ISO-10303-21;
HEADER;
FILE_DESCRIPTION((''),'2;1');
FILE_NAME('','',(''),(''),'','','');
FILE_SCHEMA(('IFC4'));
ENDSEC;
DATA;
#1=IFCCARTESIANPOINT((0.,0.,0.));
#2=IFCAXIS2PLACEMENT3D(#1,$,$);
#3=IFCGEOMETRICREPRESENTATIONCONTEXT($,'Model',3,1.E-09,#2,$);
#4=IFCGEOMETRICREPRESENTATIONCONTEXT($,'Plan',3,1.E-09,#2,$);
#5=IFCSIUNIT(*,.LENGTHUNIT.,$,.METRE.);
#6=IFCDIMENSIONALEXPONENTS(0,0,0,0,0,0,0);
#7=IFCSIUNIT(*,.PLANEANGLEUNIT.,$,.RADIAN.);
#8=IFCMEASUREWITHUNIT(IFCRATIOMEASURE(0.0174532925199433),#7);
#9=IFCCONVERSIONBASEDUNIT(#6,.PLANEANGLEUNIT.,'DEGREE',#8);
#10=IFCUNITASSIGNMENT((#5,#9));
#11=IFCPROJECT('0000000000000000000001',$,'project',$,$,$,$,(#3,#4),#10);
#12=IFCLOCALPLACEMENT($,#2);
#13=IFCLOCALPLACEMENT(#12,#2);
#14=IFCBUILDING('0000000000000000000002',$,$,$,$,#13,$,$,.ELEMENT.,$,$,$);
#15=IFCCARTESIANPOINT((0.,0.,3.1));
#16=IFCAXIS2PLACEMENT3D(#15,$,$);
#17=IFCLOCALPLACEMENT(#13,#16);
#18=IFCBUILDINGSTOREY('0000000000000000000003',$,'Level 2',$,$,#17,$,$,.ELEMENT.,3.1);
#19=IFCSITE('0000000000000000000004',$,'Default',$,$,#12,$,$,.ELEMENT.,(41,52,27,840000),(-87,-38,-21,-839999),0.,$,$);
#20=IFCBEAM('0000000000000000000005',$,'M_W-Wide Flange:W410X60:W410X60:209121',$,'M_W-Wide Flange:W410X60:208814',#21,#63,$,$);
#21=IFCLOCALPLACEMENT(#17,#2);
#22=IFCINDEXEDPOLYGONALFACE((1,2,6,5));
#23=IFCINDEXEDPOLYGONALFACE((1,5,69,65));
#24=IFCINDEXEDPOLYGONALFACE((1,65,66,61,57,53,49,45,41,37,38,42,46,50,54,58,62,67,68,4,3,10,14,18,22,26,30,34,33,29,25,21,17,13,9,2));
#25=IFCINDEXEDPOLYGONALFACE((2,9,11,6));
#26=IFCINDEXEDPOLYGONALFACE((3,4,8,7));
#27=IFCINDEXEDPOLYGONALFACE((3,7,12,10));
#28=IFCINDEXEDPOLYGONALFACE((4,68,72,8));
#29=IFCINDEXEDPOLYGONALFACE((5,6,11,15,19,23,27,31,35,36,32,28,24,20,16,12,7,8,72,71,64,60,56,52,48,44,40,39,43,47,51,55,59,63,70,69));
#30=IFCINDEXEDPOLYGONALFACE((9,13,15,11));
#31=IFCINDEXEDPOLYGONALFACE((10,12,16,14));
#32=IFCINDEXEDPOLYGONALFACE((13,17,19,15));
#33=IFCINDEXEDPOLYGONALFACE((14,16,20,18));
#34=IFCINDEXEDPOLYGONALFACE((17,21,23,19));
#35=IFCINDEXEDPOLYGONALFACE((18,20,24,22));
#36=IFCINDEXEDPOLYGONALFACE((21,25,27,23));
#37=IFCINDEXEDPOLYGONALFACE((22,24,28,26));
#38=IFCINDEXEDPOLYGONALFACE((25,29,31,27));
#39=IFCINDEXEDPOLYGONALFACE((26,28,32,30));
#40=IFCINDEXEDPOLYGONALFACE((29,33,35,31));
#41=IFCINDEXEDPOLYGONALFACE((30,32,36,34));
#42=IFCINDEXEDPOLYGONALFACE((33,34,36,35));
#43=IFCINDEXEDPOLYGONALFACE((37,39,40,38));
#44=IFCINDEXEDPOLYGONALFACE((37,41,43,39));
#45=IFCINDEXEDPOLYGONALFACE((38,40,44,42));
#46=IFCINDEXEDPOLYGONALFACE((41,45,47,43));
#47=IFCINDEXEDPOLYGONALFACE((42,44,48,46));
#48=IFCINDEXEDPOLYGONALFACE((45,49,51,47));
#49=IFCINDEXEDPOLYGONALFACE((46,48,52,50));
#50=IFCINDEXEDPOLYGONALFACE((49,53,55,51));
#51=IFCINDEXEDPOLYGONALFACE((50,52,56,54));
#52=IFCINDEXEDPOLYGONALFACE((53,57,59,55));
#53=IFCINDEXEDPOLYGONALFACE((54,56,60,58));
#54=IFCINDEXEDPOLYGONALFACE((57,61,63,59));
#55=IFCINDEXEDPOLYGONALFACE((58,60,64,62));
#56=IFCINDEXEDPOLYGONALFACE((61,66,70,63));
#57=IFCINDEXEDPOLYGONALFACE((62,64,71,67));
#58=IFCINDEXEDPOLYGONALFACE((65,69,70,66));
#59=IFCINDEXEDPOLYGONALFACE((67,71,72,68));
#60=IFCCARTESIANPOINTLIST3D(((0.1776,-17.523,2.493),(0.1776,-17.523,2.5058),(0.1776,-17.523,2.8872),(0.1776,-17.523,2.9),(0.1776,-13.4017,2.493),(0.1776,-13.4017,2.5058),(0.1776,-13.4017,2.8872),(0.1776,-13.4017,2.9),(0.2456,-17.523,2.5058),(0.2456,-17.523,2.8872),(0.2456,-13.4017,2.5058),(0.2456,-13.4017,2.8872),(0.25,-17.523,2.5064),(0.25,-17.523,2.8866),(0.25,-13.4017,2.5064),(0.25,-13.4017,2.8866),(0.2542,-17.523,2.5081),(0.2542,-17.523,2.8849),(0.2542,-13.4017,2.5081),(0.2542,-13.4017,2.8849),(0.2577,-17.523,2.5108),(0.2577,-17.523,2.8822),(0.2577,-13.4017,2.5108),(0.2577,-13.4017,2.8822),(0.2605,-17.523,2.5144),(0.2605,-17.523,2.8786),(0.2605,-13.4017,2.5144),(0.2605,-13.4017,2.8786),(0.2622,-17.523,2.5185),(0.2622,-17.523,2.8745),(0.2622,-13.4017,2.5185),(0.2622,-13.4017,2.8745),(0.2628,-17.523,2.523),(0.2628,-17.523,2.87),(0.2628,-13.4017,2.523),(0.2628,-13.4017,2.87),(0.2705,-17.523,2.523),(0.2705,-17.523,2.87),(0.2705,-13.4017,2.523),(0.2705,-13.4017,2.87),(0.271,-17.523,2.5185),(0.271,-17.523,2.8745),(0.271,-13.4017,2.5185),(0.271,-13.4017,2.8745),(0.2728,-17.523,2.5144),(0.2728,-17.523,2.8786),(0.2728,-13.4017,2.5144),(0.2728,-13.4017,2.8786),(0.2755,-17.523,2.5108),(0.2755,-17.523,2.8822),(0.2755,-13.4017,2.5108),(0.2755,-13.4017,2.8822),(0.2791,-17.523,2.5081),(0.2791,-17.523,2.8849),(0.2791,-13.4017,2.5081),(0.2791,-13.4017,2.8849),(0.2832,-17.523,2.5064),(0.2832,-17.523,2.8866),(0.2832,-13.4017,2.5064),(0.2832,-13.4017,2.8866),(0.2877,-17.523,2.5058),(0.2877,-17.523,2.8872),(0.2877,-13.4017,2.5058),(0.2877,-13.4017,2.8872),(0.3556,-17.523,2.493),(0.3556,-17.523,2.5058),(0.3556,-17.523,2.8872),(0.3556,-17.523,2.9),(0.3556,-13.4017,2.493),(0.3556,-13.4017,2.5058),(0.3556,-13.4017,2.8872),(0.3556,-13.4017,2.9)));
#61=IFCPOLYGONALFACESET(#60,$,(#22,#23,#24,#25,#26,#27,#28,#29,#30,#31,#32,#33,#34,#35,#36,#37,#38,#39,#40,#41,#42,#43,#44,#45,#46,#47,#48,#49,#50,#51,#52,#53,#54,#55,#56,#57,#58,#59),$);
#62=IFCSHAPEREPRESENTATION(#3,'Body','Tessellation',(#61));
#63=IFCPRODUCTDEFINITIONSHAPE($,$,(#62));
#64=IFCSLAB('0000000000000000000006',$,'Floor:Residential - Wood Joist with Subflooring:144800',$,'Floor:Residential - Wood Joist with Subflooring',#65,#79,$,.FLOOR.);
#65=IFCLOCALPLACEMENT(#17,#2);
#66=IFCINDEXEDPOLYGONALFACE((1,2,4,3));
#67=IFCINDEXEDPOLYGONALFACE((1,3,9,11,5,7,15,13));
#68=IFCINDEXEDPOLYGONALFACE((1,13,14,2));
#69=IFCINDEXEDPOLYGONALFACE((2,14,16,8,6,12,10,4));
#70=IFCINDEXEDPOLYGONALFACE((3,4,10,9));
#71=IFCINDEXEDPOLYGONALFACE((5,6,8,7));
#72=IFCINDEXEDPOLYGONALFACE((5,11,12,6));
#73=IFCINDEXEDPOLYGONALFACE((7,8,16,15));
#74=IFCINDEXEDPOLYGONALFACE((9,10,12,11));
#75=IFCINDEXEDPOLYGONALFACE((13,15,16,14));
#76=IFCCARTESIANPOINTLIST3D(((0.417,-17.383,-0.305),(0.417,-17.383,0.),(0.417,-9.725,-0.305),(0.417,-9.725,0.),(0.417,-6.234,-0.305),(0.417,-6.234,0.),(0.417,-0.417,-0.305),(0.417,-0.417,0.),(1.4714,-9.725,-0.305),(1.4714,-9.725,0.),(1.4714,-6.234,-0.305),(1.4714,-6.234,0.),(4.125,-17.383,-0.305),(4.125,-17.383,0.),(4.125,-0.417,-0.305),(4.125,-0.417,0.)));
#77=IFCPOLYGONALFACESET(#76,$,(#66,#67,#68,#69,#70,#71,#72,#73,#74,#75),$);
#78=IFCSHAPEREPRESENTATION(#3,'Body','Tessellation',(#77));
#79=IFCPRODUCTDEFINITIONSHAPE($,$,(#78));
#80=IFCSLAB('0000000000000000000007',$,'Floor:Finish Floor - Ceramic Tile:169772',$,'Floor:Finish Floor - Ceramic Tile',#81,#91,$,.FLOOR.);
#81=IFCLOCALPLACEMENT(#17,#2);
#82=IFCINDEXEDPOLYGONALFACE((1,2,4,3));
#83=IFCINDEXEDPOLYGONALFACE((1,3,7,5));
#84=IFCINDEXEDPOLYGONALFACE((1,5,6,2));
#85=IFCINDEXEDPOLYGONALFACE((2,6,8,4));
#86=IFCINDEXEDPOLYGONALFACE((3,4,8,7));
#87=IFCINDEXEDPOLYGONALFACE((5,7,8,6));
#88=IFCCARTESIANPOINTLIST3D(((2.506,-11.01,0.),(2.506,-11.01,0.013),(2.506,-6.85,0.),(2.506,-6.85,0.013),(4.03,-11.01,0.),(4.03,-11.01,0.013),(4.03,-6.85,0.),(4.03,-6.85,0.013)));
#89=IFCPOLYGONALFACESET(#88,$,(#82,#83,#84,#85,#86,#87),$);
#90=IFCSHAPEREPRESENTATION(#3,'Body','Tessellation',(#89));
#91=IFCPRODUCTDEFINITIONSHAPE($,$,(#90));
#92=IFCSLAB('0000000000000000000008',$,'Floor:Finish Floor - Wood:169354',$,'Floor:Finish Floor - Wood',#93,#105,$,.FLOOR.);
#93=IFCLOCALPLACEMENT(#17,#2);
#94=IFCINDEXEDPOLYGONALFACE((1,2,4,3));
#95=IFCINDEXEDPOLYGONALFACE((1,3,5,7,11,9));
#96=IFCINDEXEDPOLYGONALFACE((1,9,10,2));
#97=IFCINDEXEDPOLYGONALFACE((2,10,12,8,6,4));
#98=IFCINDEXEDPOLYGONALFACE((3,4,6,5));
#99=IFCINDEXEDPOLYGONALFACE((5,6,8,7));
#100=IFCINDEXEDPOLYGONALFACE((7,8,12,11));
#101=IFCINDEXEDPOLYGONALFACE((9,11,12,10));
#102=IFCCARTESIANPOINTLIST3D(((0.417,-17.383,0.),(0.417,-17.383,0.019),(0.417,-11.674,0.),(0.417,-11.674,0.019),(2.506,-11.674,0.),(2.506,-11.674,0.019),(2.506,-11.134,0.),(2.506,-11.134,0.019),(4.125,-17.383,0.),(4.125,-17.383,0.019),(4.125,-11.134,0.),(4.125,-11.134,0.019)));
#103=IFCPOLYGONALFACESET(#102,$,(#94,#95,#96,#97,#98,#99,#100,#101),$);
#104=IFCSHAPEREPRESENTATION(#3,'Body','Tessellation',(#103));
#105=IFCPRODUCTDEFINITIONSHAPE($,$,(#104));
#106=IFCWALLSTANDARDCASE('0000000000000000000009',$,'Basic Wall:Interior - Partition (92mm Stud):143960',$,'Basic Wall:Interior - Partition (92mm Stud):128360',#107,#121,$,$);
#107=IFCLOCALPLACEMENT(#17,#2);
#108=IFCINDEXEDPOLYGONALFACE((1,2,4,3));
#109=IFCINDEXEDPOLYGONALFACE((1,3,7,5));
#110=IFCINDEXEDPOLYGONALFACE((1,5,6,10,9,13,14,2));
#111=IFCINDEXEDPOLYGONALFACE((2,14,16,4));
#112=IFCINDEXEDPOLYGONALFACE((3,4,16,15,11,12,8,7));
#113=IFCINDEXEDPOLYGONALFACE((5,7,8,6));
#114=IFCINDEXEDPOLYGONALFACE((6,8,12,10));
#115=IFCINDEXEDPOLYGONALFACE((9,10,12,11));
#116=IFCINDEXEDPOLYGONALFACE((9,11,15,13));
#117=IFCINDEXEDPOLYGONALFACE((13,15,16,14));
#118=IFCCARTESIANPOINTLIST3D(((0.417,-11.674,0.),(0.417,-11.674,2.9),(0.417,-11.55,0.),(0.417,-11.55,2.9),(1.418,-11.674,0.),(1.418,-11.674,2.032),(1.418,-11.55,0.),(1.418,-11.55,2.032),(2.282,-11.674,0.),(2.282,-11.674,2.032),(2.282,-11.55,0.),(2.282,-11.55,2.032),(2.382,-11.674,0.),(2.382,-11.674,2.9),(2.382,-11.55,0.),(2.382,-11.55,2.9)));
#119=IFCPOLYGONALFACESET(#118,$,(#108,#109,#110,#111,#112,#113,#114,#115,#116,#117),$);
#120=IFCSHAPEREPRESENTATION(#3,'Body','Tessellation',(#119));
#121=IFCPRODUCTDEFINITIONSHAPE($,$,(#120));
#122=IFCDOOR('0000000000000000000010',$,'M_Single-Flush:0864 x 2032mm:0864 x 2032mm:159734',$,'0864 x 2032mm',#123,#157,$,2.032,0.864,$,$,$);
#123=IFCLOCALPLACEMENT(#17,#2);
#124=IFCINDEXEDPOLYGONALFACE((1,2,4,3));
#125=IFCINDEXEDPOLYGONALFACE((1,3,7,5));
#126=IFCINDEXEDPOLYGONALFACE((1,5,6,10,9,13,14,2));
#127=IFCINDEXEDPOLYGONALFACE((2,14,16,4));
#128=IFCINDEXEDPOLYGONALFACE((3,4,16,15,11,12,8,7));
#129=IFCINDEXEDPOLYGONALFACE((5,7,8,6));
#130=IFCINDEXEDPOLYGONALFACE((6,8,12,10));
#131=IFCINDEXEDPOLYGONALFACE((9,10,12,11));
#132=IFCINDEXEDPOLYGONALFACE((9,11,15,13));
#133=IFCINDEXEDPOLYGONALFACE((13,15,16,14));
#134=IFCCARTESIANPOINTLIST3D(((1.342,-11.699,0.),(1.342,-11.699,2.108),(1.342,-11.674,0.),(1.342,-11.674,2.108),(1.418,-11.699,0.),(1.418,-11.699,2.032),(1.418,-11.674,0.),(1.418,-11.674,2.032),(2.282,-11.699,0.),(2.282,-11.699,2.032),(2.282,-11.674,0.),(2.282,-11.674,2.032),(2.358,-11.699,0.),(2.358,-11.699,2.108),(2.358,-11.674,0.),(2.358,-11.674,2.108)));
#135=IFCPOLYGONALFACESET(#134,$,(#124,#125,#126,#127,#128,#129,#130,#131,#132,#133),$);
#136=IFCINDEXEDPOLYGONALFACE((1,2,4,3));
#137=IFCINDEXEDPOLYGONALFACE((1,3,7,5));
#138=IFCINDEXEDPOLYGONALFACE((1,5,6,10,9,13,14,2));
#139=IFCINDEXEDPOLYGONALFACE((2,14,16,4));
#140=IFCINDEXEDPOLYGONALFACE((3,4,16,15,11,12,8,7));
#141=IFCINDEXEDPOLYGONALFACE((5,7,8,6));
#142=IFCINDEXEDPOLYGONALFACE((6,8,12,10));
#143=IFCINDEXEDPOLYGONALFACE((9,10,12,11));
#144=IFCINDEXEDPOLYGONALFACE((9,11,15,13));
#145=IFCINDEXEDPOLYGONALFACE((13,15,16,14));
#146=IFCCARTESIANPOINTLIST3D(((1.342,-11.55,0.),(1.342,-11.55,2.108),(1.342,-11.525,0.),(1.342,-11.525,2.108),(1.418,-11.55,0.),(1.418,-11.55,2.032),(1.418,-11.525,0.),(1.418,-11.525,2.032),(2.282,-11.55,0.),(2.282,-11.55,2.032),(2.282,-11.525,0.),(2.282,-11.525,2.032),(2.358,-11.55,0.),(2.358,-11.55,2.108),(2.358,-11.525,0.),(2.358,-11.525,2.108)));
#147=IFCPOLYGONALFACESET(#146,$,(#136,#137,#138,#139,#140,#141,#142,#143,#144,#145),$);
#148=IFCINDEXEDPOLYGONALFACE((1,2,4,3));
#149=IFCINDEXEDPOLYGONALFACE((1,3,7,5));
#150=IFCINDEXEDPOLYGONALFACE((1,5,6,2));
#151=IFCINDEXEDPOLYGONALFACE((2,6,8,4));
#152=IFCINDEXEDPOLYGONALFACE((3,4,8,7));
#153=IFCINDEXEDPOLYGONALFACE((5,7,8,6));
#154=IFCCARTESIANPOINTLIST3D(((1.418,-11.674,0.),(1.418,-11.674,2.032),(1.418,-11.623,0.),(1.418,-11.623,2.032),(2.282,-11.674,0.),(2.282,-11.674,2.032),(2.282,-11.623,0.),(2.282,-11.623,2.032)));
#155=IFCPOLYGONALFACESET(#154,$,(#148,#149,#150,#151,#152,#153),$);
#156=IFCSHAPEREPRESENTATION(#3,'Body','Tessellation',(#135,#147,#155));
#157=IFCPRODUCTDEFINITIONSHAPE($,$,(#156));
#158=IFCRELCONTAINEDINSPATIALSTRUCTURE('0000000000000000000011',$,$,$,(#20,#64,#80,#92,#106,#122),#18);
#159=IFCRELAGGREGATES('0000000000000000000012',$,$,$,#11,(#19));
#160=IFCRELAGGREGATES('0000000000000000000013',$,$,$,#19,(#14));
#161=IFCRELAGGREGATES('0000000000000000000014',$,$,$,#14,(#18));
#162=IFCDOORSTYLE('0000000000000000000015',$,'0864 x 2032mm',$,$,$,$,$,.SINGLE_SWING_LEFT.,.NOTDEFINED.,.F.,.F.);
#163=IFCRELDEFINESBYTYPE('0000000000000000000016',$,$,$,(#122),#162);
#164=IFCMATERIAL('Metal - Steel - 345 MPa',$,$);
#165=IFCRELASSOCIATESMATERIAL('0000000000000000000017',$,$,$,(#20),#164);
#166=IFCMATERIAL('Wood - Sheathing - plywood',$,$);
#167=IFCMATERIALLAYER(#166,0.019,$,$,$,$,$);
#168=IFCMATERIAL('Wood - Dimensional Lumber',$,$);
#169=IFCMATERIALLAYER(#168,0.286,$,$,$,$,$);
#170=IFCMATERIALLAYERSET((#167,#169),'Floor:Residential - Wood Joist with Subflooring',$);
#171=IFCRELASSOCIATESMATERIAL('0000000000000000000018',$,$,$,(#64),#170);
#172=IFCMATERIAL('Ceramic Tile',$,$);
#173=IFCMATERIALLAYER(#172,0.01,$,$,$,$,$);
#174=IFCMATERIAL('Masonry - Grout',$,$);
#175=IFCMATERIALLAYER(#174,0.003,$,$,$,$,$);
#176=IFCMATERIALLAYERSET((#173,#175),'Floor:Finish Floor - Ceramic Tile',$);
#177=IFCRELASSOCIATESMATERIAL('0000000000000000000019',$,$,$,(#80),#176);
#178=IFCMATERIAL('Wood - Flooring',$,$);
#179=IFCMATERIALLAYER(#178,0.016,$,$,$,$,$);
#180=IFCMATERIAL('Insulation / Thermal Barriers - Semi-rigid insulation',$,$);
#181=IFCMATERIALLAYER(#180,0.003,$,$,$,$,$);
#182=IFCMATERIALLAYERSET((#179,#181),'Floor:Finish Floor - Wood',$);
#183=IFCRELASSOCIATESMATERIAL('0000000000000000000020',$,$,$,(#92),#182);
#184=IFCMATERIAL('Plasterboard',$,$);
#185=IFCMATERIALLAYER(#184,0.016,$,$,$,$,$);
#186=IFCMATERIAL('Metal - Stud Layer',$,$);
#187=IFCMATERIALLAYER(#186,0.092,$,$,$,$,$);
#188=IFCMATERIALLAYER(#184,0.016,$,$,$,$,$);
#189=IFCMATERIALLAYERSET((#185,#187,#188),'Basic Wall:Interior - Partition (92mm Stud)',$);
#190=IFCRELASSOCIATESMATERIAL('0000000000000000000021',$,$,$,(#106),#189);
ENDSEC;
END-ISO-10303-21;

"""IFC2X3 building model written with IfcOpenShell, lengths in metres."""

from ifc_helpers import new_model, entity, si_unit, converted_unit, frame, frame_2d, origin, origin_2d_with_axis, place, context, project, spatial, polyline, circle_curve, parameter, trimmed, segment, composite_curve, rectangle, outline, extrude, source, transform, mapped, material, layer, layer_set, layer_usage, type_object, type_shapes, element, fill, save


model = new_model("IFC2X3")

# Units and contexts
model_context = context("Model", 3, precision=1e-09, world=origin())
plan_context = context("Plan", 3, precision=1e-09, world=origin())
ifc_project = project(units=[si_unit("LENGTHUNIT", "METRE"), converted_unit("PLANEANGLEUNIT", "DEGREE", entity("IfcRatioMeasure", 0.0174532925199433), si_unit("PLANEANGLEUNIT", "RADIAN"), dimensions=[0, 0, 0, 0, 0, 0, 0])], contexts=[model_context, plan_context])

# Site, building, storey
site_placement = place(None, origin())
site = spatial("IfcSite", under=ifc_project, at=site_placement, Name="Default", CompositionType="ELEMENT", RefLatitude=(41, 52, 27, 840000), RefLongitude=(-87, -38, -21, -839999), RefElevation=0.0)
building_placement = place(site_placement, origin())
building = spatial("IfcBuilding", under=site, at=building_placement, CompositionType="ELEMENT")
storey_placement = place(building_placement, frame((0.0, 0.0, 3.1)))
storey = spatial("IfcBuildingStorey", under=building, at=storey_placement, Name="Level 2", CompositionType="ELEMENT", Elevation=3.1)

# Beam
ifc_material_1 = material(Name="Metal - Steel - 345 MPa")
beam_placement = place(storey_placement, frame((0.2666, -13.4017, 2.9), z_axis=(0.0, 0.0, 1.0), x_axis=(-1.0, 0.0, 0.0)))
element("IfcBeam", 1, at=beam_placement, inside=storey, material=ifc_material_1, Name="M_W-Wide Flange:W410X60:W410X60:209121", ObjectType="M_W-Wide Flange:W410X60:208814", context=model_context, shape_type="SweptSolid", body=[
    extrude(outline(composite_curve([segment(polyline([(0.1907, -0.089), (0.2035, -0.089)]), True, "CONTINUOUS"), segment(polyline([(0.2035, -0.089), (0.2035, 0.089)]), True, "CONTINUOUS"), segment(polyline([(0.2035, 0.089), (0.1907, 0.089)]), True, "CONTINUOUS"), segment(polyline([(0.1907, 0.089), (0.1907, 0.021)]), True, "CONTINUOUS"), segment(trimmed(circle_curve(frame_2d((0.1735, 0.021), x_axis=(1.0, 0.0)), 0.0172), [parameter(270.0)], [parameter(360.0)], True, "PARAMETER"), False, "CONTINUOUS"), segment(polyline([(0.1735, 0.0038), (-0.1735, 0.0038)]), True, "CONTINUOUS"), segment(trimmed(circle_curve(frame_2d((-0.1735, 0.021), x_axis=(0.0, -1.0)), 0.0172), [parameter(270.0)], [parameter(360.0)], True, "PARAMETER"), False, "CONTINUOUS"), segment(polyline([(-0.1907, 0.021), (-0.1907, 0.089)]), True, "CONTINUOUS"), segment(polyline([(-0.1907, 0.089), (-0.2035, 0.089)]), True, "CONTINUOUS"), segment(polyline([(-0.2035, 0.089), (-0.2035, -0.089)]), True, "CONTINUOUS"), segment(polyline([(-0.2035, -0.089), (-0.1907, -0.089)]), True, "CONTINUOUS"), segment(polyline([(-0.1907, -0.089), (-0.1907, -0.0211)]), True, "CONTINUOUS"), segment(trimmed(circle_curve(frame_2d((-0.1735, -0.0211), x_axis=(-1.0, 0.0)), 0.0172), [parameter(270.0)], [parameter(0.0)], True, "PARAMETER"), False, "CONTINUOUS"), segment(polyline([(-0.1735, -0.0039), (0.1735, -0.0039)]), True, "CONTINUOUS"), segment(trimmed(circle_curve(frame_2d((0.1735, -0.0211), x_axis=(0.0, 1.0)), 0.0172), [parameter(270.0)], [parameter(0.0)], True, "PARAMETER"), False, "CONTINUOUS"), segment(polyline([(0.1907, -0.0211), (0.1907, -0.089)]), True, "CONTINUOUS")], self_intersect=False)), frame((0.0, 4.1213, -0.2035), z_axis=(0.0, -1.0, 0.0), x_axis=(0.0, 0.0, -1.0)), (0.0, 0.0, 1.0), 4.1213),
])

# Slabs
ifc_material_2 = material(Name="Wood - Sheathing - plywood")
ifc_layer_1 = layer(ifc_material_2, 0.019)
ifc_material_3 = material(Name="Wood - Dimensional Lumber")
ifc_layer_2 = layer(ifc_material_3, 0.286)
ifc_layer_set_1 = layer_set([ifc_layer_1, ifc_layer_2], Name="Floor:Residential - Wood Joist with Subflooring")
ifc_layer_usage_1 = layer_usage(ifc_layer_set_1, "AXIS3", "POSITIVE", 0.0)
slab_1_placement = place(storey_placement, frame((0.417, -17.383, -0.305)))
element("IfcSlab", 2, at=slab_1_placement, inside=storey, material=ifc_layer_usage_1, Name="Floor:Residential - Wood Joist with Subflooring:144800", ObjectType="Floor:Residential - Wood Joist with Subflooring", PredefinedType="FLOOR", context=model_context, shape_type="SweptSolid", body=[
    extrude(outline(polyline([(-1.854, 8.483), (-1.854, -8.483), (1.854, -8.483), (1.854, -0.825), (0.7996, -0.825), (0.7996, 2.666), (1.854, 2.666), (1.854, 8.483), (-1.854, 8.483)])), frame((1.854, 8.483, 0.305), z_axis=(0.0, 0.0, -1.0), x_axis=(-1.0, 0.0, 0.0)), (0.0, 0.0, 1.0), 0.305),
])
ifc_material_4 = material(Name="Ceramic Tile")
ifc_layer_3 = layer(ifc_material_4, 0.01)
ifc_material_5 = material(Name="Masonry - Grout")
ifc_layer_4 = layer(ifc_material_5, 0.003)
ifc_layer_set_2 = layer_set([ifc_layer_3, ifc_layer_4], Name="Floor:Finish Floor - Ceramic Tile")
ifc_layer_usage_2 = layer_usage(ifc_layer_set_2, "AXIS3", "POSITIVE", 0.0)
slab_2_placement = place(storey_placement, frame((2.506, -11.01, 0.0)))
element("IfcSlab", 3, at=slab_2_placement, inside=storey, material=ifc_layer_usage_2, Name="Floor:Finish Floor - Ceramic Tile:169772", ObjectType="Floor:Finish Floor - Ceramic Tile", PredefinedType="FLOOR", context=model_context, shape_type="SweptSolid", body=[
    extrude(rectangle(XDim=4.16, YDim=1.524, at=frame_2d((0.0, 0.0), x_axis=(0.0, -1.0))), frame((0.762, 2.08, 0.013), z_axis=(0.0, 0.0, -1.0), x_axis=(-1.0, 0.0, 0.0)), (0.0, 0.0, 1.0), 0.013),
])
ifc_material_6 = material(Name="Wood - Flooring")
ifc_layer_5 = layer(ifc_material_6, 0.016)
ifc_material_7 = material(Name="Insulation / Thermal Barriers - Semi-rigid insulation")
ifc_layer_6 = layer(ifc_material_7, 0.003)
ifc_layer_set_3 = layer_set([ifc_layer_5, ifc_layer_6], Name="Floor:Finish Floor - Wood")
ifc_layer_usage_3 = layer_usage(ifc_layer_set_3, "AXIS3", "POSITIVE", 0.0)
slab_3_placement = place(storey_placement, frame((0.417, -17.383, 0.0)))
element("IfcSlab", 4, at=slab_3_placement, inside=storey, material=ifc_layer_usage_3, Name="Floor:Finish Floor - Wood:169354", ObjectType="Floor:Finish Floor - Wood", PredefinedType="FLOOR", context=model_context, shape_type="SweptSolid", body=[
    extrude(outline(polyline([(-1.854, -3.1245), (1.854, -3.1245), (1.854, 2.5845), (-0.235, 2.5845), (-0.235, 3.1245), (-1.854, 3.1245), (-1.854, -3.1245)])), frame((1.854, 3.1245, 0.019), z_axis=(0.0, 0.0, -1.0), x_axis=(-1.0, 0.0, 0.0)), (0.0, 0.0, 1.0), 0.019),
])

# Shared definitions
ifc_material_8 = material(Name="Metal - Stud Layer")
ifc_material_9 = material(Name="Plasterboard")

# Wall, opening, door
ifc_layer_7 = layer(ifc_material_9, 0.016)
ifc_layer_8 = layer(ifc_material_8, 0.092)
ifc_layer_9 = layer(ifc_material_9, 0.016)
ifc_layer_set_4 = layer_set([ifc_layer_7, ifc_layer_8, ifc_layer_9], Name="Basic Wall:Interior - Partition (92mm Stud)")
ifc_layer_usage_4 = layer_usage(ifc_layer_set_4, "AXIS2", "NEGATIVE", 0.062)
wall_1_placement = place(storey_placement, frame((2.382, -11.612, 0.0), z_axis=(0.0, 0.0, 1.0), x_axis=(-1.0, 0.0, 0.0)))
wall_1 = element("IfcWallStandardCase", 5, at=wall_1_placement, inside=storey, material=ifc_layer_usage_4, Name="Basic Wall:Interior - Partition (92mm Stud):143960", ObjectType="Basic Wall:Interior - Partition (92mm Stud):128360", context=model_context, shape_type="SweptSolid", body=[
    extrude(rectangle(XDim=1.965, YDim=0.124, at=frame_2d((0.9825, 0.0), x_axis=(-1.0, 0.0))), origin(), (0.0, 0.0, 1.0), 2.9),
])
opening_1_placement = place(wall_1_placement, frame((0.1, -0.062, 0.0)))
opening_1 = element("IfcOpeningElement", 6, at=opening_1_placement, cuts=wall_1, ObjectType="Opening", context=model_context, shape_type="SweptSolid", body=[
    extrude(rectangle(XDim=0.864, YDim=2.032, at=frame_2d((1.016, 0.432), x_axis=(0.0, -1.0))), frame((0.0, 0.0, 0.0), z_axis=(0.0, 1.0, 0.0), x_axis=(0.0, 0.0, 1.0)), (0.0, 0.0, 1.0), 0.124),
])
door_style = type_object("IfcDoorStyle", Name="0864 x 2032mm", ConstructionType="NOTDEFINED", OperationType="SINGLE_SWING_LEFT", ParameterTakesPrecedence=False, Sizeable=False)
shared_shape_1 = source(origin(), model_context, "Body", "SweptSolid", [
    extrude(outline(polyline([(-0.508, -1.073), (0.508, -1.073), (0.508, 1.035), (0.432, 1.035), (0.432, -0.997), (-0.432, -0.997), (-0.432, 1.035), (-0.508, 1.035), (-0.508, -1.073)])), frame((0.432, 0.149, 1.035), z_axis=(0.0, -1.0, 0.0), x_axis=(-1.0, 0.0, 0.0)), (0.0, 0.0, 1.0), 0.025),
    extrude(outline(polyline([(-1.073, -0.508), (1.035, -0.508), (1.035, -0.432), (-0.997, -0.432), (-0.997, 0.432), (1.035, 0.432), (1.035, 0.508), (-1.073, 0.508), (-1.073, -0.508)])), frame((0.432, 0.0, 1.035), z_axis=(0.0, -1.0, 0.0), x_axis=(0.0, 0.0, -1.0)), (0.0, 0.0, 1.0), 0.025),
    extrude(rectangle(XDim=0.864, YDim=0.051, at=origin_2d_with_axis()), frame((0.432, 0.0985, 0.0)), (0.0, 0.0, 1.0), 2.032),
])
type_shapes(door_style, [shared_shape_1])
door_placement = place(opening_1_placement, origin())
door = element("IfcDoor", 7, at=door_placement, inside=storey, type_object=door_style, Name="M_Single-Flush:0864 x 2032mm:0864 x 2032mm:159734", ObjectType="0864 x 2032mm", OverallHeight=2.032, OverallWidth=0.864, context=model_context, shape_type="MappedRepresentation", body=[
    mapped(shared_shape_1, transform((0.0, 0.0, 0.0), scale=1.0)),
])
fill(opening_1, door)

save(model, "model.ifc")
